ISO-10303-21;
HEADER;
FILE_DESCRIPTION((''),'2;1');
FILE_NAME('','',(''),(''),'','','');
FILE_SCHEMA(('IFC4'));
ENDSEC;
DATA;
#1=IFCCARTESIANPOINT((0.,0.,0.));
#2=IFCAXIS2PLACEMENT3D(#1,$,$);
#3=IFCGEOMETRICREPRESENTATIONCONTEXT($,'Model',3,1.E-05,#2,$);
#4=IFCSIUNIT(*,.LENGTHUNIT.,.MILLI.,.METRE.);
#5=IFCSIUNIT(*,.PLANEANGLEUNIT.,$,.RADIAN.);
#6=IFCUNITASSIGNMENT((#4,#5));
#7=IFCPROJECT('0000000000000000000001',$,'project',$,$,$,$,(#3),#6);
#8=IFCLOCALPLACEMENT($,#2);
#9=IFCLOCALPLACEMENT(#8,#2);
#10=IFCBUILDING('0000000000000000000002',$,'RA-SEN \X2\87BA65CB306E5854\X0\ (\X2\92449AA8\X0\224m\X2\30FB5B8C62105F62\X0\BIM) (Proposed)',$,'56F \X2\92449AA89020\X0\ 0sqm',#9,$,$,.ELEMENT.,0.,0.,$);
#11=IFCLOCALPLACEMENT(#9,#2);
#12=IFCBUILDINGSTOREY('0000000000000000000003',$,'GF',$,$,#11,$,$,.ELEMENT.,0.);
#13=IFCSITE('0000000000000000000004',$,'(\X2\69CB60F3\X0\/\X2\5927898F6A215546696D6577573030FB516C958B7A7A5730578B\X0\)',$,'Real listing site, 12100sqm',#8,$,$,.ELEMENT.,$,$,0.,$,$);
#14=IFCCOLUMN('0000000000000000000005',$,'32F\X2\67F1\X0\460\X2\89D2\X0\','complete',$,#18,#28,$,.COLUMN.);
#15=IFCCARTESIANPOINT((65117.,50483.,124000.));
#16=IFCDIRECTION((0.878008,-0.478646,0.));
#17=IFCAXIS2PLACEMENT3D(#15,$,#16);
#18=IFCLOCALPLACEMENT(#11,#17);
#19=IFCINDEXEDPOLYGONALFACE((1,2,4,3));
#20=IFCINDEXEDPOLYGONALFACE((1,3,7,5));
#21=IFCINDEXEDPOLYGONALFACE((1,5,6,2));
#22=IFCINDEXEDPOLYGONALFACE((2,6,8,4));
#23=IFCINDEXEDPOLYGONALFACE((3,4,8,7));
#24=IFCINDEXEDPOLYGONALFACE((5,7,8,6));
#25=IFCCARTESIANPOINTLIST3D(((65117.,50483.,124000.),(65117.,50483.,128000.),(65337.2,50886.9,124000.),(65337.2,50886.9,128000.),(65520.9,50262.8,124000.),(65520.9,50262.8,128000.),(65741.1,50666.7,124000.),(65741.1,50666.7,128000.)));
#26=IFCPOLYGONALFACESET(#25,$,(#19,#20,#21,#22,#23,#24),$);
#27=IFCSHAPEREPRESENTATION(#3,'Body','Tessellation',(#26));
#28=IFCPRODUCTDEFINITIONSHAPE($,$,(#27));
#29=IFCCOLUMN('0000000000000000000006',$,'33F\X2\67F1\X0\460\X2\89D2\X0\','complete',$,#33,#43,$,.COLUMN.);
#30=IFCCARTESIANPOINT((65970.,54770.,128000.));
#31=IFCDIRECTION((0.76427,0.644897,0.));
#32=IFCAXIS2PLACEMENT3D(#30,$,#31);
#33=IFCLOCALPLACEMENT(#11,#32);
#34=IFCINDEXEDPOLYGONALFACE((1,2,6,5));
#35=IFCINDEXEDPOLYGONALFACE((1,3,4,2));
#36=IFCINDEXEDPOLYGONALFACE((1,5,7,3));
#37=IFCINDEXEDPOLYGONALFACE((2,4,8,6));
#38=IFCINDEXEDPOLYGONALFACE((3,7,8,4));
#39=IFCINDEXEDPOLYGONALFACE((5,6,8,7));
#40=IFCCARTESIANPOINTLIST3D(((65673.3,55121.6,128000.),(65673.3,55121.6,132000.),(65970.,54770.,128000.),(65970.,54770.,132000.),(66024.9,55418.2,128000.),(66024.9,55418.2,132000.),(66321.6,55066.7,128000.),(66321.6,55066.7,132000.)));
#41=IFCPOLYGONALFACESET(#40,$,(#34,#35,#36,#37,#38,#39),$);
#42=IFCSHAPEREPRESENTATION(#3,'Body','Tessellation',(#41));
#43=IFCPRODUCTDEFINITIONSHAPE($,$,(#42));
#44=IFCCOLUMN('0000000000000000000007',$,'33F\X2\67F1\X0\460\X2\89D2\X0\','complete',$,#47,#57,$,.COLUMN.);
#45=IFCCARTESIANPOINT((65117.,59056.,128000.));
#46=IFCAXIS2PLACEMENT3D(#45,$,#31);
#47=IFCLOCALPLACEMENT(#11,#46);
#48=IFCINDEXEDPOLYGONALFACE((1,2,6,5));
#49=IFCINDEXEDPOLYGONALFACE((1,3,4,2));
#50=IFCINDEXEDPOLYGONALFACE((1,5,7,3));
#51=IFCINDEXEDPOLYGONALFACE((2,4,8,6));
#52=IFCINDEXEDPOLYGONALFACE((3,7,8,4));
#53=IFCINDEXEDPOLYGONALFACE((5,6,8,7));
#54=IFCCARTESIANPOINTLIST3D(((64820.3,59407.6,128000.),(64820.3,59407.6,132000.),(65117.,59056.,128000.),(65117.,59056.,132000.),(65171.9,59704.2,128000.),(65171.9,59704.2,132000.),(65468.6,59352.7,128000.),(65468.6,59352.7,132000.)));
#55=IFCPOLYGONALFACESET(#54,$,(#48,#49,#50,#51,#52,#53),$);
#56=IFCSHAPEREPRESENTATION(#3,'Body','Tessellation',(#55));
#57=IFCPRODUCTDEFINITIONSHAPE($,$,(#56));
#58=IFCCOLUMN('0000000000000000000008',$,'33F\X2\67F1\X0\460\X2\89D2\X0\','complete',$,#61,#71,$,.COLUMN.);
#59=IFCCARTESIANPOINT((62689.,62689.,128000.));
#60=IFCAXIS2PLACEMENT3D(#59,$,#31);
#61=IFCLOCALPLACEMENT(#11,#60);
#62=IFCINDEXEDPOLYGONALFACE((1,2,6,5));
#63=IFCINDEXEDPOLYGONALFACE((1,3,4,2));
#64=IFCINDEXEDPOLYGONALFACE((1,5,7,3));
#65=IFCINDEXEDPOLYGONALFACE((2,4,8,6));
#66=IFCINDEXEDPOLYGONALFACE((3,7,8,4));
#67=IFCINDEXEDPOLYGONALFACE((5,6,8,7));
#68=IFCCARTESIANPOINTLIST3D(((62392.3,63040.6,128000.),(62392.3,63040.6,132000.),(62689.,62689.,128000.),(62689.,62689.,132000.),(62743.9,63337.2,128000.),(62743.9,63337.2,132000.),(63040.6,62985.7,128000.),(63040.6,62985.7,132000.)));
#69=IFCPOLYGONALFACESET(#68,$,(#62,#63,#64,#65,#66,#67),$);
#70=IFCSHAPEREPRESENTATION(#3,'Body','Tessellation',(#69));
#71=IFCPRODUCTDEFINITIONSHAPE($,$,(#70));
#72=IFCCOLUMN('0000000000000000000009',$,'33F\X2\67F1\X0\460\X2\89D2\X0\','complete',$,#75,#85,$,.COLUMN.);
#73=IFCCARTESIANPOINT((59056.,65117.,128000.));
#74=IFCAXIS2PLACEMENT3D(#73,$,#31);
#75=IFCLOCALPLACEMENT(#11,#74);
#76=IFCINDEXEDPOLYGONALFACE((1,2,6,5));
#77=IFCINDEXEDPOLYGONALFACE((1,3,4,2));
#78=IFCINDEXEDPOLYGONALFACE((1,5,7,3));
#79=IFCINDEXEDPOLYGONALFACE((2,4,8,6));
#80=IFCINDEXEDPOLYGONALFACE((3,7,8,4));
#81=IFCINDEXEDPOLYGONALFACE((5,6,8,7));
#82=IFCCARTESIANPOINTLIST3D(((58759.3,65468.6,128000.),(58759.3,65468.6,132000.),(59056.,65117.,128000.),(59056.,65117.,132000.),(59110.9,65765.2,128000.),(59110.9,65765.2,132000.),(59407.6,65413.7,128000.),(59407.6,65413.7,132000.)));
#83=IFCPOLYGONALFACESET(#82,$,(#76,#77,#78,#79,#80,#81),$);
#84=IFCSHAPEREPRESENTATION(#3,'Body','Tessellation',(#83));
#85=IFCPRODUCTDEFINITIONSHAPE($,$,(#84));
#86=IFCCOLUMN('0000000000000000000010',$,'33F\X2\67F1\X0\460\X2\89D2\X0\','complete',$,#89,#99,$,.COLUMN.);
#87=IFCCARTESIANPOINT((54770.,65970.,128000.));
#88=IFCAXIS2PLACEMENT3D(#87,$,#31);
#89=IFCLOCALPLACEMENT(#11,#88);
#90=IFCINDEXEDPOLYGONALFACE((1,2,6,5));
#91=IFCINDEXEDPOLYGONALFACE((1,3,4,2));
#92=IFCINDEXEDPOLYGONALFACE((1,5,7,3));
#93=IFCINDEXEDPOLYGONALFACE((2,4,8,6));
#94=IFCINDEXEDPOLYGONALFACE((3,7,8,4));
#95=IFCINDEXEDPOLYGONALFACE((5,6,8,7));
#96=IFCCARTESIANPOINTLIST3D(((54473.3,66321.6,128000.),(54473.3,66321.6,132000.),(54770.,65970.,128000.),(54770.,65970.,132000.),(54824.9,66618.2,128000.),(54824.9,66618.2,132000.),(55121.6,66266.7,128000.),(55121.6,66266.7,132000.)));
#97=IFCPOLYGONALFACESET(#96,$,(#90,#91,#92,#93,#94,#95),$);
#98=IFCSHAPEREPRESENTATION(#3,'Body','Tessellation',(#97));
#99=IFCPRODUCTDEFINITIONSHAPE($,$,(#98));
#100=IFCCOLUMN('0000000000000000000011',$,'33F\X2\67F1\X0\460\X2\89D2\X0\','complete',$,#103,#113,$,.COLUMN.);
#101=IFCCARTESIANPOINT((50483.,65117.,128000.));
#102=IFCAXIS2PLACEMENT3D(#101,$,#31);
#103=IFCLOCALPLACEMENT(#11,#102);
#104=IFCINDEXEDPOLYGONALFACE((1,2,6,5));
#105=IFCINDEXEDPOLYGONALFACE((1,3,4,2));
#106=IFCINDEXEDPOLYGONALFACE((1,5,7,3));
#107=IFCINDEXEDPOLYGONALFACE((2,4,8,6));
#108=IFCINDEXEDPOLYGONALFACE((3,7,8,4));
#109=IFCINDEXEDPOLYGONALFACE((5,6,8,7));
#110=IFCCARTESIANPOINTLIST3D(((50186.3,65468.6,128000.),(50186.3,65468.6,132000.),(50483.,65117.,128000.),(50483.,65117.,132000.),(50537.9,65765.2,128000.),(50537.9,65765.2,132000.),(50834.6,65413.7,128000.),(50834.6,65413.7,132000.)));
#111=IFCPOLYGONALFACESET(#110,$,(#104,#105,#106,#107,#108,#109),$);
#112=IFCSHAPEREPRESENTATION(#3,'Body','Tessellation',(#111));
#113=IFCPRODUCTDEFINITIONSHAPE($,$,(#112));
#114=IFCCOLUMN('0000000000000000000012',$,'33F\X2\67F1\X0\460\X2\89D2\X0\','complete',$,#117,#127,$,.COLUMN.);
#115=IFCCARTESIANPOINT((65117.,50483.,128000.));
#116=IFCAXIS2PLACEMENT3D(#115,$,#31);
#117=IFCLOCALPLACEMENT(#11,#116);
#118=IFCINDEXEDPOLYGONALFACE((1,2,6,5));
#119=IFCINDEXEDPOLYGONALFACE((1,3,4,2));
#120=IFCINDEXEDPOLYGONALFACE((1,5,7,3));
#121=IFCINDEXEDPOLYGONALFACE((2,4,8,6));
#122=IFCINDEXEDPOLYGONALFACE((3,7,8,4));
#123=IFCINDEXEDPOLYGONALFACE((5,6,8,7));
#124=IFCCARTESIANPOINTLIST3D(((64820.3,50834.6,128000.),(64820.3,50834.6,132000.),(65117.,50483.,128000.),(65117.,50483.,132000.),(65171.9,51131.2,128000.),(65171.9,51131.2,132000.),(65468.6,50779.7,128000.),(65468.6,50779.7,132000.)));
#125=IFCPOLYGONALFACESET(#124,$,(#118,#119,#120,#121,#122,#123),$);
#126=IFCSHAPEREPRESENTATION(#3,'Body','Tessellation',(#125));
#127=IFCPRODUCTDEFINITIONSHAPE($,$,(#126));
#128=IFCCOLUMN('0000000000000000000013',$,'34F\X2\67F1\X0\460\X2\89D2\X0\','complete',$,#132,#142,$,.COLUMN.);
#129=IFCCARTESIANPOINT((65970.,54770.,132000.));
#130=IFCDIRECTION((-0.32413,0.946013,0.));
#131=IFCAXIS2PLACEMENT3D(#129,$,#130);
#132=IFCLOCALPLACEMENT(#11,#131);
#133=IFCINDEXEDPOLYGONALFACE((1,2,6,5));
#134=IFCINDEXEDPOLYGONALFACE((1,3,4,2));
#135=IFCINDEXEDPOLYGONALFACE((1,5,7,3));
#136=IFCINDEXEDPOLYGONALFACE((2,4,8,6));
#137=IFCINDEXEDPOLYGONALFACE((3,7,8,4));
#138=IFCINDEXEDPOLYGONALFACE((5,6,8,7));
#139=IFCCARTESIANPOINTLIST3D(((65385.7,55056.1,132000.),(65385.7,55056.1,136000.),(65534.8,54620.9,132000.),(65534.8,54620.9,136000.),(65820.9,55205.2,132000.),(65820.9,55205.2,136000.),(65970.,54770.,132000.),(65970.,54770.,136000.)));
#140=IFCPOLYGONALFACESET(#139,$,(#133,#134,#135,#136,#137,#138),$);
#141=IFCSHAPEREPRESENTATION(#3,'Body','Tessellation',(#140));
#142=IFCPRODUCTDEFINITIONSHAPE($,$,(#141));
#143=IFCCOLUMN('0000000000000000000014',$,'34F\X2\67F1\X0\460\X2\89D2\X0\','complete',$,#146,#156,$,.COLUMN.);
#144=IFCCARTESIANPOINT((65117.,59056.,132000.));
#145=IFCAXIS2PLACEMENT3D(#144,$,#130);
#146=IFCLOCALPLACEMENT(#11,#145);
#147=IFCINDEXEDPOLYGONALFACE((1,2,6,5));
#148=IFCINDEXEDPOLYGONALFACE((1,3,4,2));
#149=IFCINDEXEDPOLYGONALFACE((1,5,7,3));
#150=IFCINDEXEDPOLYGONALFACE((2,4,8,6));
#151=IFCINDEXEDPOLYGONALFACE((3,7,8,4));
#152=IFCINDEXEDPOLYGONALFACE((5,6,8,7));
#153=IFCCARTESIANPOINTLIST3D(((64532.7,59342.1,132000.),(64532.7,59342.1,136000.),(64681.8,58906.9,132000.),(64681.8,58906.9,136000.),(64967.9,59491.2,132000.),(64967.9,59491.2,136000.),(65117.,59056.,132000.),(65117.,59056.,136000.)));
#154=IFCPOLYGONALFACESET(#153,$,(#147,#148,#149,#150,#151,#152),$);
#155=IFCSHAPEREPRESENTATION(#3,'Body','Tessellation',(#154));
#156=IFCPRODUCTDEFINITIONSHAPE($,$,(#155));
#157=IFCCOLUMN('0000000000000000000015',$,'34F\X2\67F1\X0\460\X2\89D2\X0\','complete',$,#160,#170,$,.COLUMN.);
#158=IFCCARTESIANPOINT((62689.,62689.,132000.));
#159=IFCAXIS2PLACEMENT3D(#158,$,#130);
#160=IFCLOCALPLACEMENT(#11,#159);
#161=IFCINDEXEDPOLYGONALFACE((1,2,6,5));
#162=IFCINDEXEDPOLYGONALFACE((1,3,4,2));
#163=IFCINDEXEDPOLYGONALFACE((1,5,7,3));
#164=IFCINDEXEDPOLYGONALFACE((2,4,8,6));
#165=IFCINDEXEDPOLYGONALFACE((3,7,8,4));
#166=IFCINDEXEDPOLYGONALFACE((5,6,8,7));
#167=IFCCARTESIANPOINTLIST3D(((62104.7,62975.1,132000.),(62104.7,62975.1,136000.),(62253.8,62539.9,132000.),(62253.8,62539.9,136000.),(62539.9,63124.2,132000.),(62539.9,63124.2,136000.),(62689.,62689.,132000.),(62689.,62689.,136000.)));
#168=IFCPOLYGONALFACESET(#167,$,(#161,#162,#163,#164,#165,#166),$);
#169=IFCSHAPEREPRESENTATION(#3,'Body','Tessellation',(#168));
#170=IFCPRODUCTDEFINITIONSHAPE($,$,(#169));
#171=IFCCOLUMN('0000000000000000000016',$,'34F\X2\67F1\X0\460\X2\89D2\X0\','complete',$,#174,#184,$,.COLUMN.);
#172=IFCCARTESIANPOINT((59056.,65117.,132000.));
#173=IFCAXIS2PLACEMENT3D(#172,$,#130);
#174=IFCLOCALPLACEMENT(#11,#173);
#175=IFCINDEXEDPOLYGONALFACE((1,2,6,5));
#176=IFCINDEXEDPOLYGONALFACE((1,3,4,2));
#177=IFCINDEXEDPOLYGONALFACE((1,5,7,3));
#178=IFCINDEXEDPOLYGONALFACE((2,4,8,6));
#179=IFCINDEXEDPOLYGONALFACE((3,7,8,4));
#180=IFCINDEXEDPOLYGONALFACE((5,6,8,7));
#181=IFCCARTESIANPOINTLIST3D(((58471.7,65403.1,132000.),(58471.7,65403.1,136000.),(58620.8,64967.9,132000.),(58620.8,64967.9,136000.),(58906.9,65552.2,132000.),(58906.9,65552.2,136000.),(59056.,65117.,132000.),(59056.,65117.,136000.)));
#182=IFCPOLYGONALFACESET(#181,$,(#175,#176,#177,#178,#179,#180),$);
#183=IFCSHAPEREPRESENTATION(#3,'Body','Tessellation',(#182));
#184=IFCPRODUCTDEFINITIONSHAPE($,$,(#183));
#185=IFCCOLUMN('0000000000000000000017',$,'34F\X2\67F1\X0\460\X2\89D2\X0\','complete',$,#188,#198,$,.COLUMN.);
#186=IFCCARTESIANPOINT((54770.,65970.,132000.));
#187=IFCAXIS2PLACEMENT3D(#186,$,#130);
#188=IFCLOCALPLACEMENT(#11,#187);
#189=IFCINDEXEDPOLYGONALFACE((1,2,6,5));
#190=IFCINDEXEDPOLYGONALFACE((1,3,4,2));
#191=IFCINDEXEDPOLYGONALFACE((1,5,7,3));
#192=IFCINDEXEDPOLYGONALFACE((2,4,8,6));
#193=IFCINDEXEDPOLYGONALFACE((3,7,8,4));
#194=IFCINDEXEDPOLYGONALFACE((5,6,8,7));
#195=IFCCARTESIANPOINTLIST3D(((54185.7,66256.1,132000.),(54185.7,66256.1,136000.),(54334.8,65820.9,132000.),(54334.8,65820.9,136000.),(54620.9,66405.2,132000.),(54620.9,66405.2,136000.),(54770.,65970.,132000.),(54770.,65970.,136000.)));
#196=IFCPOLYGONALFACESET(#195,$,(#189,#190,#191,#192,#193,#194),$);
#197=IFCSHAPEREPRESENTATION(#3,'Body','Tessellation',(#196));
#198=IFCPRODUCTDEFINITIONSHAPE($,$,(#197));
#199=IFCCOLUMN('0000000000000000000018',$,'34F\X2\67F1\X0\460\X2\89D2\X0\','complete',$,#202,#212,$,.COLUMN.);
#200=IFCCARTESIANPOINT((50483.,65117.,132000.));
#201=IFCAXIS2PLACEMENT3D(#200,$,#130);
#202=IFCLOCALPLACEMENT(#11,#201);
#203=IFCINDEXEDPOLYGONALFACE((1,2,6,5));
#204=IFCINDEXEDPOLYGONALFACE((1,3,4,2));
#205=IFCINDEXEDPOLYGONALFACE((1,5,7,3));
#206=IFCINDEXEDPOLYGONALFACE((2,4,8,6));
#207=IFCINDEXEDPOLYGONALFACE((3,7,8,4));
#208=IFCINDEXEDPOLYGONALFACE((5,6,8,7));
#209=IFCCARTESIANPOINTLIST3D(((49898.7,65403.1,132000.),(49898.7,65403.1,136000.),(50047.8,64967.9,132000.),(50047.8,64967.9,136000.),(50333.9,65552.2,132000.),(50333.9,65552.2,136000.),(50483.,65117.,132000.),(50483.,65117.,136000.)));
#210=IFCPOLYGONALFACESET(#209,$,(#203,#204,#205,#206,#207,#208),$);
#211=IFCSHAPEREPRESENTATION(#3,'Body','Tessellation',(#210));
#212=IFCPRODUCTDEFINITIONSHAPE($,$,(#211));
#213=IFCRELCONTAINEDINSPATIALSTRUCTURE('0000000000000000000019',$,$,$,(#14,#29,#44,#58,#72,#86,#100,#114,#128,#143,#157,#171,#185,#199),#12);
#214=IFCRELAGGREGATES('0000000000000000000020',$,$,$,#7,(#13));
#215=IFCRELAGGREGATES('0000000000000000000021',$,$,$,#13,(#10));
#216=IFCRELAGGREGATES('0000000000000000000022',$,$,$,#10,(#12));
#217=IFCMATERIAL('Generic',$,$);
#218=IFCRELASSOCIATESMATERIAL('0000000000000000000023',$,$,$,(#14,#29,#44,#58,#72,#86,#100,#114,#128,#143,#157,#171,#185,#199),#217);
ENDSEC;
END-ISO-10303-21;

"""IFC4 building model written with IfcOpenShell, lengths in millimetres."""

from ifc_helpers import new_model, si_unit, frame, frame_2d, origin, place, context, project, spatial, rectangle, extrude, material, element, save


model = new_model("IFC4")

# Units and contexts
model_context = context("Model", 3, precision=1e-05, world=origin())
ifc_project = project(units=[si_unit("LENGTHUNIT", "METRE", prefix="MILLI"), si_unit("PLANEANGLEUNIT", "RADIAN")], contexts=[model_context])

# Site, building, storey
site_placement = place(None, origin())
site = spatial("IfcSite", under=ifc_project, at=site_placement, Name="(構想/大規模商業敷地・公開空地型)", ObjectType="Real listing site, 12100sqm", CompositionType="ELEMENT", RefElevation=0.0)
building_placement = place(site_placement, origin())
building = spatial("IfcBuilding", under=site, at=building_placement, Name="RA-SEN 螺旋の塔 (鉄骨224m・完成形BIM) (Proposed)", ObjectType="56F 鉄骨造 0sqm", CompositionType="ELEMENT", ElevationOfRefHeight=0.0, ElevationOfTerrain=0.0)
storey_placement = place(building_placement, origin())
storey = spatial("IfcBuildingStorey", under=building, at=storey_placement, Name="GF", CompositionType="ELEMENT", Elevation=0.0)

# Columns
ifc_material = material(Name="Generic")
column_1_placement = place(storey_placement, frame((65117.0, 50483.0, 124000.0), x_axis=(0.878008, -0.478646, 0.0)))
element("IfcColumn", 1, at=column_1_placement, inside=storey, material=ifc_material, Name="32F柱460角", Description="complete", PredefinedType="COLUMN", context=model_context, shape_type="SweptSolid", body=[
    extrude(rectangle(XDim=460.0, YDim=460.0, at=frame_2d((230.0, 230.0))), frame((65117.0, 50483.0, 124000.0), x_axis=(0.878008, -0.478646, 0.0)), (0.0, 0.0, 1.0), 4000.0),
])
column_2_placement = place(storey_placement, frame((65970.0, 54770.0, 128000.0), x_axis=(0.76427, 0.644897, 0.0)))
element("IfcColumn", 2, at=column_2_placement, inside=storey, material=ifc_material, Name="33F柱460角", Description="complete", PredefinedType="COLUMN", context=model_context, shape_type="SweptSolid", body=[
    extrude(rectangle(XDim=460.0, YDim=460.0, at=frame_2d((230.0, 230.0))), frame((65970.0, 54770.0, 128000.0), x_axis=(0.76427, 0.644897, 0.0)), (0.0, 0.0, 1.0), 4000.0),
])
column_3_placement = place(storey_placement, frame((65117.0, 59056.0, 128000.0), x_axis=(0.76427, 0.644897, 0.0)))
element("IfcColumn", 3, at=column_3_placement, inside=storey, material=ifc_material, Name="33F柱460角", Description="complete", PredefinedType="COLUMN", context=model_context, shape_type="SweptSolid", body=[
    extrude(rectangle(XDim=460.0, YDim=460.0, at=frame_2d((230.0, 230.0))), frame((65117.0, 59056.0, 128000.0), x_axis=(0.76427, 0.644897, 0.0)), (0.0, 0.0, 1.0), 4000.0),
])
column_4_placement = place(storey_placement, frame((62689.0, 62689.0, 128000.0), x_axis=(0.76427, 0.644897, 0.0)))
element("IfcColumn", 4, at=column_4_placement, inside=storey, material=ifc_material, Name="33F柱460角", Description="complete", PredefinedType="COLUMN", context=model_context, shape_type="SweptSolid", body=[
    extrude(rectangle(XDim=460.0, YDim=460.0, at=frame_2d((230.0, 230.0))), frame((62689.0, 62689.0, 128000.0), x_axis=(0.76427, 0.644897, 0.0)), (0.0, 0.0, 1.0), 4000.0),
])
column_5_placement = place(storey_placement, frame((59056.0, 65117.0, 128000.0), x_axis=(0.76427, 0.644897, 0.0)))
element("IfcColumn", 5, at=column_5_placement, inside=storey, material=ifc_material, Name="33F柱460角", Description="complete", PredefinedType="COLUMN", context=model_context, shape_type="SweptSolid", body=[
    extrude(rectangle(XDim=460.0, YDim=460.0, at=frame_2d((230.0, 230.0))), frame((59056.0, 65117.0, 128000.0), x_axis=(0.76427, 0.644897, 0.0)), (0.0, 0.0, 1.0), 4000.0),
])
column_6_placement = place(storey_placement, frame((54770.0, 65970.0, 128000.0), x_axis=(0.76427, 0.644897, 0.0)))
element("IfcColumn", 6, at=column_6_placement, inside=storey, material=ifc_material, Name="33F柱460角", Description="complete", PredefinedType="COLUMN", context=model_context, shape_type="SweptSolid", body=[
    extrude(rectangle(XDim=460.0, YDim=460.0, at=frame_2d((230.0, 230.0))), frame((54770.0, 65970.0, 128000.0), x_axis=(0.76427, 0.644897, 0.0)), (0.0, 0.0, 1.0), 4000.0),
])
column_7_placement = place(storey_placement, frame((50483.0, 65117.0, 128000.0), x_axis=(0.76427, 0.644897, 0.0)))
element("IfcColumn", 7, at=column_7_placement, inside=storey, material=ifc_material, Name="33F柱460角", Description="complete", PredefinedType="COLUMN", context=model_context, shape_type="SweptSolid", body=[
    extrude(rectangle(XDim=460.0, YDim=460.0, at=frame_2d((230.0, 230.0))), frame((50483.0, 65117.0, 128000.0), x_axis=(0.76427, 0.644897, 0.0)), (0.0, 0.0, 1.0), 4000.0),
])
column_8_placement = place(storey_placement, frame((65117.0, 50483.0, 128000.0), x_axis=(0.76427, 0.644897, 0.0)))
element("IfcColumn", 8, at=column_8_placement, inside=storey, material=ifc_material, Name="33F柱460角", Description="complete", PredefinedType="COLUMN", context=model_context, shape_type="SweptSolid", body=[
    extrude(rectangle(XDim=460.0, YDim=460.0, at=frame_2d((230.0, 230.0))), frame((65117.0, 50483.0, 128000.0), x_axis=(0.76427, 0.644897, 0.0)), (0.0, 0.0, 1.0), 4000.0),
])
column_9_placement = place(storey_placement, frame((65970.0, 54770.0, 132000.0), x_axis=(-0.32413, 0.946013, 0.0)))
element("IfcColumn", 9, at=column_9_placement, inside=storey, material=ifc_material, Name="34F柱460角", Description="complete", PredefinedType="COLUMN", context=model_context, shape_type="SweptSolid", body=[
    extrude(rectangle(XDim=460.0, YDim=460.0, at=frame_2d((230.0, 230.0))), frame((65970.0, 54770.0, 132000.0), x_axis=(-0.32413, 0.946013, 0.0)), (0.0, 0.0, 1.0), 4000.0),
])
column_10_placement = place(storey_placement, frame((65117.0, 59056.0, 132000.0), x_axis=(-0.32413, 0.946013, 0.0)))
element("IfcColumn", 10, at=column_10_placement, inside=storey, material=ifc_material, Name="34F柱460角", Description="complete", PredefinedType="COLUMN", context=model_context, shape_type="SweptSolid", body=[
    extrude(rectangle(XDim=460.0, YDim=460.0, at=frame_2d((230.0, 230.0))), frame((65117.0, 59056.0, 132000.0), x_axis=(-0.32413, 0.946013, 0.0)), (0.0, 0.0, 1.0), 4000.0),
])
column_11_placement = place(storey_placement, frame((62689.0, 62689.0, 132000.0), x_axis=(-0.32413, 0.946013, 0.0)))
element("IfcColumn", 11, at=column_11_placement, inside=storey, material=ifc_material, Name="34F柱460角", Description="complete", PredefinedType="COLUMN", context=model_context, shape_type="SweptSolid", body=[
    extrude(rectangle(XDim=460.0, YDim=460.0, at=frame_2d((230.0, 230.0))), frame((62689.0, 62689.0, 132000.0), x_axis=(-0.32413, 0.946013, 0.0)), (0.0, 0.0, 1.0), 4000.0),
])
column_12_placement = place(storey_placement, frame((59056.0, 65117.0, 132000.0), x_axis=(-0.32413, 0.946013, 0.0)))
element("IfcColumn", 12, at=column_12_placement, inside=storey, material=ifc_material, Name="34F柱460角", Description="complete", PredefinedType="COLUMN", context=model_context, shape_type="SweptSolid", body=[
    extrude(rectangle(XDim=460.0, YDim=460.0, at=frame_2d((230.0, 230.0))), frame((59056.0, 65117.0, 132000.0), x_axis=(-0.32413, 0.946013, 0.0)), (0.0, 0.0, 1.0), 4000.0),
])
column_13_placement = place(storey_placement, frame((54770.0, 65970.0, 132000.0), x_axis=(-0.32413, 0.946013, 0.0)))
element("IfcColumn", 13, at=column_13_placement, inside=storey, material=ifc_material, Name="34F柱460角", Description="complete", PredefinedType="COLUMN", context=model_context, shape_type="SweptSolid", body=[
    extrude(rectangle(XDim=460.0, YDim=460.0, at=frame_2d((230.0, 230.0))), frame((54770.0, 65970.0, 132000.0), x_axis=(-0.32413, 0.946013, 0.0)), (0.0, 0.0, 1.0), 4000.0),
])
column_14_placement = place(storey_placement, frame((50483.0, 65117.0, 132000.0), x_axis=(-0.32413, 0.946013, 0.0)))
element("IfcColumn", 14, at=column_14_placement, inside=storey, material=ifc_material, Name="34F柱460角", Description="complete", PredefinedType="COLUMN", context=model_context, shape_type="SweptSolid", body=[
    extrude(rectangle(XDim=460.0, YDim=460.0, at=frame_2d((230.0, 230.0))), frame((50483.0, 65117.0, 132000.0), x_axis=(-0.32413, 0.946013, 0.0)), (0.0, 0.0, 1.0), 4000.0),
])

save(model, "model.ifc")
